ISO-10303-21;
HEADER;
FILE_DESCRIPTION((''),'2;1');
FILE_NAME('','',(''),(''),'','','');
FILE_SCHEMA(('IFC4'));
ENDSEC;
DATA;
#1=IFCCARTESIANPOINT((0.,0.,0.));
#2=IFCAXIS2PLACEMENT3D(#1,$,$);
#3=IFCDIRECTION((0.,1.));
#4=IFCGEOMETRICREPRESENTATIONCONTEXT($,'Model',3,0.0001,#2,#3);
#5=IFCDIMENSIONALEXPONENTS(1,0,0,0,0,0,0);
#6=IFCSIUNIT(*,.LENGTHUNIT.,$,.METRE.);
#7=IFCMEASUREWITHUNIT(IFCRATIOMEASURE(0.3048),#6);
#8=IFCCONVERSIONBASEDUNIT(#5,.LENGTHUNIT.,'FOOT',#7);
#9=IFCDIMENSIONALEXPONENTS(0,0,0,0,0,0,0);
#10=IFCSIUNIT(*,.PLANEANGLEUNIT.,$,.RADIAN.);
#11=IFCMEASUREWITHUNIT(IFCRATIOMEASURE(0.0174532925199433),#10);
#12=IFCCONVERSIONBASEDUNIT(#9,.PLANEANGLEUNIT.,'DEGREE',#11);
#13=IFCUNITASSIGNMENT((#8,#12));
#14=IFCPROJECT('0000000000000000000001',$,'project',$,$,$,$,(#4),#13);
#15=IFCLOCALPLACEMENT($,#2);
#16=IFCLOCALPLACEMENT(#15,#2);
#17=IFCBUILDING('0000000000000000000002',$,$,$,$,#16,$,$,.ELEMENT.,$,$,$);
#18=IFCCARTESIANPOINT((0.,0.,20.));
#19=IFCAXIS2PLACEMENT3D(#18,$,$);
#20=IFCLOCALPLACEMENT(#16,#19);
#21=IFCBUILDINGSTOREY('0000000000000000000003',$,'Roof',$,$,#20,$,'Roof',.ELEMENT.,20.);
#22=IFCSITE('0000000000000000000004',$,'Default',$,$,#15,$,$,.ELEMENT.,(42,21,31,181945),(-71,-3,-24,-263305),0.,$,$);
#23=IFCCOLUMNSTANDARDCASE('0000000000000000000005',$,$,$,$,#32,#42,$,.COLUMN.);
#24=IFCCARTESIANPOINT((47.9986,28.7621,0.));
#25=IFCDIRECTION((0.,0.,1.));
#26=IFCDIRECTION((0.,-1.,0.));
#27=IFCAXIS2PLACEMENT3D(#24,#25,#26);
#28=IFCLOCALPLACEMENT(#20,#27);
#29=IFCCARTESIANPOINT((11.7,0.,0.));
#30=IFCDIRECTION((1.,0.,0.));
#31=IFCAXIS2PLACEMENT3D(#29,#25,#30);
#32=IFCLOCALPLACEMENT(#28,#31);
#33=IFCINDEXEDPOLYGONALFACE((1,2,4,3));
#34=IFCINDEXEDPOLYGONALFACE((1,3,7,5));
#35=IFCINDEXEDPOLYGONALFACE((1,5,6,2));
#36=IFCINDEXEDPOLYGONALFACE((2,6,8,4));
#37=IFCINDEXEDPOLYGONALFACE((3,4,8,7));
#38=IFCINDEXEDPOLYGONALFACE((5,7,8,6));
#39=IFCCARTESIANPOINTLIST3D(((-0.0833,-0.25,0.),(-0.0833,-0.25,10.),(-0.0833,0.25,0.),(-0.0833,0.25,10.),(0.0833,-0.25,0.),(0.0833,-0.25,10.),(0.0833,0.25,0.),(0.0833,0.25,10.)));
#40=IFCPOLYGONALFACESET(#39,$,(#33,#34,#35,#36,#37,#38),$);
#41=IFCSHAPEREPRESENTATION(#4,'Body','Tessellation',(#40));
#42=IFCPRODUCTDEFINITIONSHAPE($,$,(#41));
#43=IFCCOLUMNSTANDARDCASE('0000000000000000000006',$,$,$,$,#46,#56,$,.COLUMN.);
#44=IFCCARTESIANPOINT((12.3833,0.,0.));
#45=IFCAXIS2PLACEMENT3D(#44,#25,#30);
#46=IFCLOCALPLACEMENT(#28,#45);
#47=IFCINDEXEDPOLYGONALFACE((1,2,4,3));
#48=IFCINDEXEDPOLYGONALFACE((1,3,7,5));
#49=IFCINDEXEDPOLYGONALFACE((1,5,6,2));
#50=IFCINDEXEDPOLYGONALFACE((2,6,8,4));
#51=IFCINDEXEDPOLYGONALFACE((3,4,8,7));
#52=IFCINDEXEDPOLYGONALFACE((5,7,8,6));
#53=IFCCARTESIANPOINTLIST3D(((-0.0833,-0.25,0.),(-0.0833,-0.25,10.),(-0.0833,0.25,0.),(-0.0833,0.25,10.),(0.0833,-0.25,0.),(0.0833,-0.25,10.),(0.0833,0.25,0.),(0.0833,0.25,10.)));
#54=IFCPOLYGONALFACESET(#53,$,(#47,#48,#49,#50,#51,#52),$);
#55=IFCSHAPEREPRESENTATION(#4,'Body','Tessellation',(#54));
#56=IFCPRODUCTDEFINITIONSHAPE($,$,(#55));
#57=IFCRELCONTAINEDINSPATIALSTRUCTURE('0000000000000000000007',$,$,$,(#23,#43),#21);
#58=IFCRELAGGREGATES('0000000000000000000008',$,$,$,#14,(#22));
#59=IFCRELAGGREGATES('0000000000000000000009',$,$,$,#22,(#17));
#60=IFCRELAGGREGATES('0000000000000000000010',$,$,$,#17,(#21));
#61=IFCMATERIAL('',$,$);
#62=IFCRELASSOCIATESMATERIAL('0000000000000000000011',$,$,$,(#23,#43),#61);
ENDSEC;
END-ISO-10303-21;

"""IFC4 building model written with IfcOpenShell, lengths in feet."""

from ifc_helpers import new_model, entity, si_unit, converted_unit, direction, frame, origin, place, context, project, spatial, rectangle, extrude, material, element, save


model = new_model("IFC4")

# Units and contexts
model_context = context("Model", 3, precision=0.0001, world=origin(), true_north=direction((0.0, 1.0)))
ifc_project = project(units=[converted_unit("LENGTHUNIT", "FOOT", entity("IfcRatioMeasure", 0.3048), si_unit("LENGTHUNIT", "METRE"), dimensions=[1, 0, 0, 0, 0, 0, 0]), converted_unit("PLANEANGLEUNIT", "DEGREE", entity("IfcRatioMeasure", 0.0174532925199433), si_unit("PLANEANGLEUNIT", "RADIAN"), dimensions=[0, 0, 0, 0, 0, 0, 0])], contexts=[model_context])

# Site, building, storey
site_placement = place(None, origin())
site = spatial("IfcSite", under=ifc_project, at=site_placement, Name="Default", CompositionType="ELEMENT", RefLatitude=(42, 21, 31, 181945), RefLongitude=(-71, -3, -24, -263305), RefElevation=0.0)
building_placement = place(site_placement, origin())
building = spatial("IfcBuilding", under=site, at=building_placement, CompositionType="ELEMENT")
storey_placement = place(building_placement, frame((0.0, 0.0, 20.0)))
storey = spatial("IfcBuildingStorey", under=building, at=storey_placement, Name="Roof", LongName="Roof", CompositionType="ELEMENT", Elevation=20.0)

# Columns
ifc_material_1 = material(Name="")
wall_placement = place(storey_placement, frame((47.9986, 28.7621, 0.0), z_axis=(0.0, 0.0, 1.0), x_axis=(0.0, -1.0, 0.0)))
for number, where, z_axis, x_axis in (
    (1, (11.7, 0.0, 0.0), (0.0, 0.0, 1.0), (1.0, 0.0, 0.0)),
    (2, (12.3833, 0.0, 0.0), (0.0, 0.0, 1.0), (1.0, 0.0, 0.0)),
):
    element("IfcColumnStandardCase", number, at=place(wall_placement, frame(where, z_axis=z_axis, x_axis=x_axis)), inside=storey, material=ifc_material_1, PredefinedType="COLUMN", context=model_context, shape_type="SweptSolid", body=[
        extrude(rectangle(XDim=0.1667, YDim=0.5), origin(), (0.0, 0.0, 1.0), 10.0),
    ])

save(model, "model.ifc")
